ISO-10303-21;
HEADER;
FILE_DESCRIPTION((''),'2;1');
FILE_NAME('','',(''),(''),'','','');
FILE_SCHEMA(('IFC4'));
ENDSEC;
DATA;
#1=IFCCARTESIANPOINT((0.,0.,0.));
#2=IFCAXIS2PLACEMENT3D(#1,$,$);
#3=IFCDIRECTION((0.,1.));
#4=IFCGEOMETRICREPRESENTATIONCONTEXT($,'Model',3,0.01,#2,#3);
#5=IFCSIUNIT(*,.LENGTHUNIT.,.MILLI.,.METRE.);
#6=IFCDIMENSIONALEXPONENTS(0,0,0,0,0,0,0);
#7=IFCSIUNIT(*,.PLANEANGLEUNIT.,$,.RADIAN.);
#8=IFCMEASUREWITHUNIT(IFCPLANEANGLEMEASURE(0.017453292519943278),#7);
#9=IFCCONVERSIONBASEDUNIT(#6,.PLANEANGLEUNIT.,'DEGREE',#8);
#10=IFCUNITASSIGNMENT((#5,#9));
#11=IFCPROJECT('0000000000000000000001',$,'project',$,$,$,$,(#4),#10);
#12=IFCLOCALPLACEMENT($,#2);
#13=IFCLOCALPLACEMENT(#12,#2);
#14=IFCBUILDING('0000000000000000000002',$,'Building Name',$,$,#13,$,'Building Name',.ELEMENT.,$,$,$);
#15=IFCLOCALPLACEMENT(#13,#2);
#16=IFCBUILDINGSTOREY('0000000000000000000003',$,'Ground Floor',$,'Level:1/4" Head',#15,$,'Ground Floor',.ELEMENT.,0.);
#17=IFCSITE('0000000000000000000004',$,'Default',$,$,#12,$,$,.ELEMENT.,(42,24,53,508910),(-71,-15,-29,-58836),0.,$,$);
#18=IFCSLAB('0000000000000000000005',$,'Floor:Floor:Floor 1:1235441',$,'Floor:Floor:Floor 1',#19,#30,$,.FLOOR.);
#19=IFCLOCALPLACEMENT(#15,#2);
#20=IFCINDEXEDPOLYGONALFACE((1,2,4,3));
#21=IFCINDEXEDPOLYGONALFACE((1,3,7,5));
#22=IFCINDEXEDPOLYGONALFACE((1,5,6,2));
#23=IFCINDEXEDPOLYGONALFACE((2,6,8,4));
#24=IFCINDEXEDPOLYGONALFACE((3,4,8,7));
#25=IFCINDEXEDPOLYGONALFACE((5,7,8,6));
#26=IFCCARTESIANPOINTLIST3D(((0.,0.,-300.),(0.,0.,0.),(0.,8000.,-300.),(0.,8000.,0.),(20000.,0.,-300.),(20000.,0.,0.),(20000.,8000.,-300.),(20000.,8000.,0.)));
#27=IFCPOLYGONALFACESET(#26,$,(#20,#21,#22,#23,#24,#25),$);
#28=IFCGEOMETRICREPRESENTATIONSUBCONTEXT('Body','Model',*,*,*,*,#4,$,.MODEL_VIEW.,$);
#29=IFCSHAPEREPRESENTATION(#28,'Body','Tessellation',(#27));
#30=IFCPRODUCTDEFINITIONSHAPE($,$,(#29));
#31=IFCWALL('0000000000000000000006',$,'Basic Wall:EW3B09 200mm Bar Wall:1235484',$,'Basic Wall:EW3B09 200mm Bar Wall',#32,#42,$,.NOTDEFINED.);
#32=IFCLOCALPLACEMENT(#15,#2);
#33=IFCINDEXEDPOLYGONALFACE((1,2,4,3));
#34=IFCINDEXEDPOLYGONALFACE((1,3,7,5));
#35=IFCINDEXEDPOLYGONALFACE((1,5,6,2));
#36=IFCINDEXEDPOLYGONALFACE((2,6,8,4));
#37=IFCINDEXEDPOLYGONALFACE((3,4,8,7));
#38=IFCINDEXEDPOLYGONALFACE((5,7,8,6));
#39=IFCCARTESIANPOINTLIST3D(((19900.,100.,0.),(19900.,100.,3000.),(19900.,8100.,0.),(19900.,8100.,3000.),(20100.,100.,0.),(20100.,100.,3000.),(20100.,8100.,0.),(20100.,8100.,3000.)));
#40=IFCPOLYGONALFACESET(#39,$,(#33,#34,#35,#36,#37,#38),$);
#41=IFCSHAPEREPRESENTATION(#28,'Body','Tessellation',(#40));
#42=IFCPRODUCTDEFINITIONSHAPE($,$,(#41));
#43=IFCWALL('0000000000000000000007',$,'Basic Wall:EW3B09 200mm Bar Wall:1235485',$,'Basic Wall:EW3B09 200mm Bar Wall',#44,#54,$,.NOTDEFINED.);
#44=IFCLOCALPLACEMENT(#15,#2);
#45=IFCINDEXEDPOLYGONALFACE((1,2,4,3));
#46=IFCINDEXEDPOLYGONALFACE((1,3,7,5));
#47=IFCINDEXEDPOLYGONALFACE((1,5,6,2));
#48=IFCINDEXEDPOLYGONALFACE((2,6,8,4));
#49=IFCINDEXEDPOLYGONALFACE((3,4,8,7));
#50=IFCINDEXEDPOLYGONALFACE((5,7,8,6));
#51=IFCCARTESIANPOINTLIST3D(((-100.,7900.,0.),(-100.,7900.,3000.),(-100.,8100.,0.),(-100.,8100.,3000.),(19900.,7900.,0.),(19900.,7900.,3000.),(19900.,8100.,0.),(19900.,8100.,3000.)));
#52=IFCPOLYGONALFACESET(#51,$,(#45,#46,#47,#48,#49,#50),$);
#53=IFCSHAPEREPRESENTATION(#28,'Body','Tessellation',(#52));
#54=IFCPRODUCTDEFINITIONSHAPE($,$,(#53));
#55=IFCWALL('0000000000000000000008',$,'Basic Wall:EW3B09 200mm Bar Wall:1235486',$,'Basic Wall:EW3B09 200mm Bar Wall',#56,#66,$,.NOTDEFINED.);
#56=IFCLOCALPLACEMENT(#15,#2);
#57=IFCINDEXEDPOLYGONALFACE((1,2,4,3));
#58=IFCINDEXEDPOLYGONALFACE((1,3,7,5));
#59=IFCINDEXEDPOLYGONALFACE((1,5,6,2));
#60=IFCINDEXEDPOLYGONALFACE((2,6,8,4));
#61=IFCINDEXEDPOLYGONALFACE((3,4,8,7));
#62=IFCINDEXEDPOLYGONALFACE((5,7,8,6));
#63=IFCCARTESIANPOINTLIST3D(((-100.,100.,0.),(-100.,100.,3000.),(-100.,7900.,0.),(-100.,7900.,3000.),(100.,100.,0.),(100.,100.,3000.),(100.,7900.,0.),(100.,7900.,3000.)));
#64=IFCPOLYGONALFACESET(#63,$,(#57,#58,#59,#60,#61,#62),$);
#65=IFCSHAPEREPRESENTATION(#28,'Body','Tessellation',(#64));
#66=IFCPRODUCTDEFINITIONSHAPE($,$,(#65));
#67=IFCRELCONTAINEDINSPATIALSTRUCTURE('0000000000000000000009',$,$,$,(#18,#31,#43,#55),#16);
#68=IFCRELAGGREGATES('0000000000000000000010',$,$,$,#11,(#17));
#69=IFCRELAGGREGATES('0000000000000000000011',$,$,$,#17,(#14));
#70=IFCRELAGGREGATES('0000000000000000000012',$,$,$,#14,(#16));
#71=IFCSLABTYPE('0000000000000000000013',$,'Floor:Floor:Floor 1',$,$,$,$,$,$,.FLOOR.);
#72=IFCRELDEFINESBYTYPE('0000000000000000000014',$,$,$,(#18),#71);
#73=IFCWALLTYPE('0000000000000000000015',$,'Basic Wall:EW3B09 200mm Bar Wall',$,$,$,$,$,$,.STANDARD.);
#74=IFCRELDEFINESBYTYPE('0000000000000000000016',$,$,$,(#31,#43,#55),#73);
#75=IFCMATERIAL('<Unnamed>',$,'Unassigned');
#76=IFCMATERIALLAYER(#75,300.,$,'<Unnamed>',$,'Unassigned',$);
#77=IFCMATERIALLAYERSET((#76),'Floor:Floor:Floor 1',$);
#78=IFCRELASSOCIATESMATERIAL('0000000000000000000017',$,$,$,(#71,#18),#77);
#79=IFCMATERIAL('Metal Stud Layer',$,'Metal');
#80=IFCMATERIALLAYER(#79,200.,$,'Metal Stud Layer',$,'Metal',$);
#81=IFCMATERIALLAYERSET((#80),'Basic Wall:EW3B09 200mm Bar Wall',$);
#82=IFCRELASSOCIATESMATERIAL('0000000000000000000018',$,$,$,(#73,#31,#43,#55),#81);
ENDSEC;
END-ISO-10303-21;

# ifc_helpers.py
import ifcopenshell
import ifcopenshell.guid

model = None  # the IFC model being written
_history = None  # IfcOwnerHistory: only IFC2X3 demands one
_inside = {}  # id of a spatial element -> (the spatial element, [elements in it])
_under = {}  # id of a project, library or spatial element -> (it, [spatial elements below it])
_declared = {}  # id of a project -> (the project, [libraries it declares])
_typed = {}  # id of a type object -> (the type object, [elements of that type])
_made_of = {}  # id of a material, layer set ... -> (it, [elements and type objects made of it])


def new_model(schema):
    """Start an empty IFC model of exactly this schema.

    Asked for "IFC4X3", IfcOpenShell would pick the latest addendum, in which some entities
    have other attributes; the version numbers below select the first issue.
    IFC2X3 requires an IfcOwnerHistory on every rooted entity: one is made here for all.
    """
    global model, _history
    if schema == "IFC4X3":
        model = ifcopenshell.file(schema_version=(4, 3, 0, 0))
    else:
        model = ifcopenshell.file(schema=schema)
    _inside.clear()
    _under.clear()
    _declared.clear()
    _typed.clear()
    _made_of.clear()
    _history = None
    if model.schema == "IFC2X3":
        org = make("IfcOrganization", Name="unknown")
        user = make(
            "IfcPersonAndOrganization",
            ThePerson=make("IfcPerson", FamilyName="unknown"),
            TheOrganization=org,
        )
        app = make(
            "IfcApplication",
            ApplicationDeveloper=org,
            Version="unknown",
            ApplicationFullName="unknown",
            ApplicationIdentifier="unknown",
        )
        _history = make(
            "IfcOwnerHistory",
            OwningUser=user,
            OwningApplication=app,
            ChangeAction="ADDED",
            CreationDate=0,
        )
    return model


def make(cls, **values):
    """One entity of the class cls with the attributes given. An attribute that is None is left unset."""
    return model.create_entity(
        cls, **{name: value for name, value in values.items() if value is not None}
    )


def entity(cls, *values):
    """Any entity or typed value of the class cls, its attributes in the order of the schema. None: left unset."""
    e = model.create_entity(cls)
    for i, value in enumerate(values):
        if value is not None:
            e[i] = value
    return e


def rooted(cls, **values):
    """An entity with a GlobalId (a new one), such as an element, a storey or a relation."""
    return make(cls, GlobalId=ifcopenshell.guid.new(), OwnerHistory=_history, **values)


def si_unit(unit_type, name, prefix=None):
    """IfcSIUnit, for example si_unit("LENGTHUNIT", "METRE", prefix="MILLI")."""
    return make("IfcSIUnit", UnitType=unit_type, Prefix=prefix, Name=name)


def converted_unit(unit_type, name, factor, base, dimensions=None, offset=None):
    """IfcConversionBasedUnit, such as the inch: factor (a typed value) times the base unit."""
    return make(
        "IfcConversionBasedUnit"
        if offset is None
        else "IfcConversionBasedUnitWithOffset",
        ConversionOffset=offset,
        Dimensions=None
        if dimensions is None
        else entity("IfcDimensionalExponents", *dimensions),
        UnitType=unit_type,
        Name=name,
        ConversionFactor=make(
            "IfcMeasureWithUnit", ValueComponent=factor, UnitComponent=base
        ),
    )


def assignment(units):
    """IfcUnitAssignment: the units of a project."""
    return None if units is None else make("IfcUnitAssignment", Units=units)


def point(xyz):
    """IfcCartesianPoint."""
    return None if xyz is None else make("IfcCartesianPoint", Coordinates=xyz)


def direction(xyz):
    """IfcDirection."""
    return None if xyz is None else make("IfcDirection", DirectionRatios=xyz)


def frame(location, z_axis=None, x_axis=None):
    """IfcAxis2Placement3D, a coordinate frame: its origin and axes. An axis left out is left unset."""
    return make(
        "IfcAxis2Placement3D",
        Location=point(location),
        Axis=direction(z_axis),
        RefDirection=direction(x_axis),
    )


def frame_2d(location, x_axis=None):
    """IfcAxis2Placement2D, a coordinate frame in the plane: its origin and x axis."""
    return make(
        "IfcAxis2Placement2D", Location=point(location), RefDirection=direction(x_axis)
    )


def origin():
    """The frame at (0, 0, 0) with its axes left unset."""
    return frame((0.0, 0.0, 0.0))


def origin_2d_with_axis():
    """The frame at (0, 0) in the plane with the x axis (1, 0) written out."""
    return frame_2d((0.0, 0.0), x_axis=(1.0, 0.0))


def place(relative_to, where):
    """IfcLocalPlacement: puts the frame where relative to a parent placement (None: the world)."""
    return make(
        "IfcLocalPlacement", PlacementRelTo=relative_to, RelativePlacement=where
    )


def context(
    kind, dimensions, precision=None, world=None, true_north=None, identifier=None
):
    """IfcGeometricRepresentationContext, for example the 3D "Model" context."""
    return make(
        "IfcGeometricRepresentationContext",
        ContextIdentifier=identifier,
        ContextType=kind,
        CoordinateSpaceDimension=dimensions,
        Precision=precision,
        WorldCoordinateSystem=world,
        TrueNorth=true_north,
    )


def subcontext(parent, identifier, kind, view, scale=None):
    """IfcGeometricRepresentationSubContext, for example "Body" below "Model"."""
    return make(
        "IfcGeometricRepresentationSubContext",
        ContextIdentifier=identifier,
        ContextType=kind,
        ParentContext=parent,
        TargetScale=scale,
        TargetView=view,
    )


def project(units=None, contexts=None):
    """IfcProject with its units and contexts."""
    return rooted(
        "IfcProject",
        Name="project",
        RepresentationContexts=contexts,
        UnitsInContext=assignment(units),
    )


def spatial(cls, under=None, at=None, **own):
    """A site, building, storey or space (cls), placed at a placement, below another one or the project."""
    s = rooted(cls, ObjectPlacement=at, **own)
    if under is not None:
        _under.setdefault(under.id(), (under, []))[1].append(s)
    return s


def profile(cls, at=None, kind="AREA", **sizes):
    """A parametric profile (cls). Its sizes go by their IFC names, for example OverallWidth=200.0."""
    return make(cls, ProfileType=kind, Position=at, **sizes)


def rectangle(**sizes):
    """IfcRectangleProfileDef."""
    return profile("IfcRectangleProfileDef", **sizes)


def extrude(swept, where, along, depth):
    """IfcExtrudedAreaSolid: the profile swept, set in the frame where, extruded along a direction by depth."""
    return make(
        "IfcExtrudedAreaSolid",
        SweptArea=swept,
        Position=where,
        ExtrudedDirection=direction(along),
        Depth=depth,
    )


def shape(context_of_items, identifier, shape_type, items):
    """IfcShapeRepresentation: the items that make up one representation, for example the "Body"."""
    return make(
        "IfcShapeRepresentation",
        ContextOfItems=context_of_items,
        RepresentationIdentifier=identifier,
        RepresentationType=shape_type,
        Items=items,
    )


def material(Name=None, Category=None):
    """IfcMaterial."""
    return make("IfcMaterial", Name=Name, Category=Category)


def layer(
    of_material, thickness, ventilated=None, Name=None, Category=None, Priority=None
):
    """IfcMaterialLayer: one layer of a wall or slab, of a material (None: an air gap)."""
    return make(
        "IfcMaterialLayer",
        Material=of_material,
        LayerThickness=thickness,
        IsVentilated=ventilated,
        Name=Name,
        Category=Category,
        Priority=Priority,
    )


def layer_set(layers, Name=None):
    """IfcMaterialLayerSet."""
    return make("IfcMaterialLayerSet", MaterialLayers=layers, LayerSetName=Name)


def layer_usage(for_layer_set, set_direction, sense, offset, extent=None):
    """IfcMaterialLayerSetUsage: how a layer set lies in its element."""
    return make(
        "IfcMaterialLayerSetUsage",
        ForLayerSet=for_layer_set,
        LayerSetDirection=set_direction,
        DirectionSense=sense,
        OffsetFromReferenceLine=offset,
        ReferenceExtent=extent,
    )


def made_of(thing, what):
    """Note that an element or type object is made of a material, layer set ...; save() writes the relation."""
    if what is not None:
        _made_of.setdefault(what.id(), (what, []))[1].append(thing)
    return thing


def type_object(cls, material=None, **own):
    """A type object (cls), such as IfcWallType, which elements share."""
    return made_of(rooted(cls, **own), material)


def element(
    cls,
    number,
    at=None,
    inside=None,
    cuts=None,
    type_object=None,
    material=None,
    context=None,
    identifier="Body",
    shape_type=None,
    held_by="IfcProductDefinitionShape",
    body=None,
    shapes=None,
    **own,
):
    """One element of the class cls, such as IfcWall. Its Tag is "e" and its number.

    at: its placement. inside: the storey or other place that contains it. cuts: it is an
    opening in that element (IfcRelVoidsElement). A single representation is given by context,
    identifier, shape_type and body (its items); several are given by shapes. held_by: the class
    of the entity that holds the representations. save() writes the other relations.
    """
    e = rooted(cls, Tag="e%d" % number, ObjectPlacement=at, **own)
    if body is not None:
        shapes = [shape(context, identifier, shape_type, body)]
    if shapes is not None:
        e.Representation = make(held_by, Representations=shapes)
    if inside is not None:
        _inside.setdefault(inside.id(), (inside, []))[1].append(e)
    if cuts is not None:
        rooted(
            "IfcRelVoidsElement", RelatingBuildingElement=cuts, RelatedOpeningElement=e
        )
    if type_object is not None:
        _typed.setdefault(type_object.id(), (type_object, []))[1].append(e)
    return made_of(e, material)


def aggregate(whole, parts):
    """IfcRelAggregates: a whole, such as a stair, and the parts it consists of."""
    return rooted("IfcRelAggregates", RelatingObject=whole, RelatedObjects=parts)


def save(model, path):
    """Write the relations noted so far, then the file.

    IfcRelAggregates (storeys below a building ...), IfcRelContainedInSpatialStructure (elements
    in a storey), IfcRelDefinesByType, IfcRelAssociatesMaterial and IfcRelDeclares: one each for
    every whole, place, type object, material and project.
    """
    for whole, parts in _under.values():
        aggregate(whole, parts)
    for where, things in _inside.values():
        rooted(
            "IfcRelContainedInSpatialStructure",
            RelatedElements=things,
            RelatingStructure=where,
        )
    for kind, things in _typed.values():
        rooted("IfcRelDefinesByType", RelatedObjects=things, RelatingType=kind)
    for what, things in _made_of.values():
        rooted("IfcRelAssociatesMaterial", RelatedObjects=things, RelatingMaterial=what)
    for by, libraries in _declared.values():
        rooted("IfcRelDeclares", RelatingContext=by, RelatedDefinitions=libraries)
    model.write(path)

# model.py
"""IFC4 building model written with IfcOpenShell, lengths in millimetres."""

from ifc_helpers import new_model, entity, si_unit, converted_unit, direction, frame, frame_2d, origin, origin_2d_with_axis, place, context, subcontext, project, spatial, rectangle, extrude, material, layer, layer_set, layer_usage, type_object, element, save


model = new_model("IFC4")

# Units and contexts
model_context = context("Model", 3, precision=0.01, world=origin(), true_north=direction((0.0, 1.0)))
body_context = subcontext(model_context, "Body", "Model", "MODEL_VIEW")
ifc_project = project(units=[si_unit("LENGTHUNIT", "METRE", prefix="MILLI"), converted_unit("PLANEANGLEUNIT", "DEGREE", entity("IfcPlaneAngleMeasure", 0.017453292519943278), si_unit("PLANEANGLEUNIT", "RADIAN"), dimensions=[0, 0, 0, 0, 0, 0, 0])], contexts=[model_context])

# Site, building, storey
site_placement = place(None, origin())
site = spatial("IfcSite", under=ifc_project, at=site_placement, Name="Default", CompositionType="ELEMENT", RefLatitude=(42, 24, 53, 508910), RefLongitude=(-71, -15, -29, -58836), RefElevation=0.0)
building_placement = place(site_placement, origin())
building = spatial("IfcBuilding", under=site, at=building_placement, Name="Building Name", LongName="Building Name", CompositionType="ELEMENT")
storey_placement = place(building_placement, origin())
storey = spatial("IfcBuildingStorey", under=building, at=storey_placement, Name="Ground Floor", ObjectType="Level:1/4\" Head", LongName="Ground Floor", CompositionType="ELEMENT", Elevation=0.0)

# Slab
ifc_material_1 = material(Name="<Unnamed>", Category="Unassigned")
ifc_layer_1 = layer(ifc_material_1, 300.0, Name="<Unnamed>", Category="Unassigned")
ifc_layer_set_1 = layer_set([ifc_layer_1], Name="Floor:Floor:Floor 1")
ifc_layer_usage_1 = layer_usage(ifc_layer_set_1, "AXIS3", "POSITIVE", 0.0)
slab_type = type_object("IfcSlabType", Name="Floor:Floor:Floor 1", PredefinedType="FLOOR", material=ifc_layer_set_1)
slab_placement = place(storey_placement, origin())
element("IfcSlab", 1, at=slab_placement, inside=storey, type_object=slab_type, material=ifc_layer_usage_1, Name="Floor:Floor:Floor 1:1235441", ObjectType="Floor:Floor:Floor 1", PredefinedType="FLOOR", context=body_context, shape_type="SweptSolid", body=[
    extrude(rectangle(XDim=8000.0, YDim=20000.0, at=origin_2d_with_axis()), frame((10000.0, 4000.0, 0.0), z_axis=(0.0, 0.0, -1.0), x_axis=(0.0, 1.0, 0.0)), (0.0, 0.0, 1.0), 300.0),
])

# Shared definitions
ifc_material_2 = material(Name="Metal Stud Layer", Category="Metal")
ifc_layer_2 = layer(ifc_material_2, 200.0, Name="Metal Stud Layer", Category="Metal")
ifc_layer_set_2 = layer_set([ifc_layer_2], Name="Basic Wall:EW3B09 200mm Bar Wall")
wall_type = type_object("IfcWallType", Name="Basic Wall:EW3B09 200mm Bar Wall", PredefinedType="STANDARD", material=ifc_layer_set_2)

# Walls
ifc_layer_usage_2 = layer_usage(ifc_layer_set_2, "AXIS2", "NEGATIVE", 100.0)
wall_1_placement = place(storey_placement, frame((20000.0, 100.0, 0.0), z_axis=(0.0, 0.0, 1.0), x_axis=(0.0, 1.0, 0.0)))
element("IfcWall", 2, at=wall_1_placement, inside=storey, type_object=wall_type, material=ifc_layer_usage_2, Name="Basic Wall:EW3B09 200mm Bar Wall:1235484", ObjectType="Basic Wall:EW3B09 200mm Bar Wall", PredefinedType="NOTDEFINED", context=body_context, shape_type="SweptSolid", body=[
    extrude(rectangle(XDim=8000.0, YDim=200.0, at=frame_2d((4000.0, 0.0), x_axis=(-1.0, 0.0))), origin(), (0.0, 0.0, 1.0), 3000.0),
])
ifc_layer_usage_3 = layer_usage(ifc_layer_set_2, "AXIS2", "NEGATIVE", 100.0)
wall_2_placement = place(storey_placement, frame((19900.0, 8000.0, 0.0), z_axis=(0.0, 0.0, 1.0), x_axis=(-1.0, 0.0, 0.0)))
element("IfcWall", 3, at=wall_2_placement, inside=storey, type_object=wall_type, material=ifc_layer_usage_3, Name="Basic Wall:EW3B09 200mm Bar Wall:1235485", ObjectType="Basic Wall:EW3B09 200mm Bar Wall", PredefinedType="NOTDEFINED", context=body_context, shape_type="SweptSolid", body=[
    extrude(rectangle(XDim=20000.0, YDim=200.0, at=frame_2d((10000.0, 0.0), x_axis=(-1.0, 0.0))), origin(), (0.0, 0.0, 1.0), 3000.0),
])
ifc_layer_usage_4 = layer_usage(ifc_layer_set_2, "AXIS2", "NEGATIVE", 100.0)
wall_3_placement = place(storey_placement, frame((0.0, 7900.0, 0.0), z_axis=(0.0, 0.0, 1.0), x_axis=(0.0, -1.0, 0.0)))
element("IfcWall", 4, at=wall_3_placement, inside=storey, type_object=wall_type, material=ifc_layer_usage_4, Name="Basic Wall:EW3B09 200mm Bar Wall:1235486", ObjectType="Basic Wall:EW3B09 200mm Bar Wall", PredefinedType="NOTDEFINED", context=body_context, shape_type="SweptSolid", body=[
    extrude(rectangle(XDim=7800.0, YDim=200.0, at=frame_2d((3900.0, 0.0), x_axis=(-1.0, 0.0))), origin(), (0.0, 0.0, 1.0), 3000.0),
])

save(model, "model.ifc")
